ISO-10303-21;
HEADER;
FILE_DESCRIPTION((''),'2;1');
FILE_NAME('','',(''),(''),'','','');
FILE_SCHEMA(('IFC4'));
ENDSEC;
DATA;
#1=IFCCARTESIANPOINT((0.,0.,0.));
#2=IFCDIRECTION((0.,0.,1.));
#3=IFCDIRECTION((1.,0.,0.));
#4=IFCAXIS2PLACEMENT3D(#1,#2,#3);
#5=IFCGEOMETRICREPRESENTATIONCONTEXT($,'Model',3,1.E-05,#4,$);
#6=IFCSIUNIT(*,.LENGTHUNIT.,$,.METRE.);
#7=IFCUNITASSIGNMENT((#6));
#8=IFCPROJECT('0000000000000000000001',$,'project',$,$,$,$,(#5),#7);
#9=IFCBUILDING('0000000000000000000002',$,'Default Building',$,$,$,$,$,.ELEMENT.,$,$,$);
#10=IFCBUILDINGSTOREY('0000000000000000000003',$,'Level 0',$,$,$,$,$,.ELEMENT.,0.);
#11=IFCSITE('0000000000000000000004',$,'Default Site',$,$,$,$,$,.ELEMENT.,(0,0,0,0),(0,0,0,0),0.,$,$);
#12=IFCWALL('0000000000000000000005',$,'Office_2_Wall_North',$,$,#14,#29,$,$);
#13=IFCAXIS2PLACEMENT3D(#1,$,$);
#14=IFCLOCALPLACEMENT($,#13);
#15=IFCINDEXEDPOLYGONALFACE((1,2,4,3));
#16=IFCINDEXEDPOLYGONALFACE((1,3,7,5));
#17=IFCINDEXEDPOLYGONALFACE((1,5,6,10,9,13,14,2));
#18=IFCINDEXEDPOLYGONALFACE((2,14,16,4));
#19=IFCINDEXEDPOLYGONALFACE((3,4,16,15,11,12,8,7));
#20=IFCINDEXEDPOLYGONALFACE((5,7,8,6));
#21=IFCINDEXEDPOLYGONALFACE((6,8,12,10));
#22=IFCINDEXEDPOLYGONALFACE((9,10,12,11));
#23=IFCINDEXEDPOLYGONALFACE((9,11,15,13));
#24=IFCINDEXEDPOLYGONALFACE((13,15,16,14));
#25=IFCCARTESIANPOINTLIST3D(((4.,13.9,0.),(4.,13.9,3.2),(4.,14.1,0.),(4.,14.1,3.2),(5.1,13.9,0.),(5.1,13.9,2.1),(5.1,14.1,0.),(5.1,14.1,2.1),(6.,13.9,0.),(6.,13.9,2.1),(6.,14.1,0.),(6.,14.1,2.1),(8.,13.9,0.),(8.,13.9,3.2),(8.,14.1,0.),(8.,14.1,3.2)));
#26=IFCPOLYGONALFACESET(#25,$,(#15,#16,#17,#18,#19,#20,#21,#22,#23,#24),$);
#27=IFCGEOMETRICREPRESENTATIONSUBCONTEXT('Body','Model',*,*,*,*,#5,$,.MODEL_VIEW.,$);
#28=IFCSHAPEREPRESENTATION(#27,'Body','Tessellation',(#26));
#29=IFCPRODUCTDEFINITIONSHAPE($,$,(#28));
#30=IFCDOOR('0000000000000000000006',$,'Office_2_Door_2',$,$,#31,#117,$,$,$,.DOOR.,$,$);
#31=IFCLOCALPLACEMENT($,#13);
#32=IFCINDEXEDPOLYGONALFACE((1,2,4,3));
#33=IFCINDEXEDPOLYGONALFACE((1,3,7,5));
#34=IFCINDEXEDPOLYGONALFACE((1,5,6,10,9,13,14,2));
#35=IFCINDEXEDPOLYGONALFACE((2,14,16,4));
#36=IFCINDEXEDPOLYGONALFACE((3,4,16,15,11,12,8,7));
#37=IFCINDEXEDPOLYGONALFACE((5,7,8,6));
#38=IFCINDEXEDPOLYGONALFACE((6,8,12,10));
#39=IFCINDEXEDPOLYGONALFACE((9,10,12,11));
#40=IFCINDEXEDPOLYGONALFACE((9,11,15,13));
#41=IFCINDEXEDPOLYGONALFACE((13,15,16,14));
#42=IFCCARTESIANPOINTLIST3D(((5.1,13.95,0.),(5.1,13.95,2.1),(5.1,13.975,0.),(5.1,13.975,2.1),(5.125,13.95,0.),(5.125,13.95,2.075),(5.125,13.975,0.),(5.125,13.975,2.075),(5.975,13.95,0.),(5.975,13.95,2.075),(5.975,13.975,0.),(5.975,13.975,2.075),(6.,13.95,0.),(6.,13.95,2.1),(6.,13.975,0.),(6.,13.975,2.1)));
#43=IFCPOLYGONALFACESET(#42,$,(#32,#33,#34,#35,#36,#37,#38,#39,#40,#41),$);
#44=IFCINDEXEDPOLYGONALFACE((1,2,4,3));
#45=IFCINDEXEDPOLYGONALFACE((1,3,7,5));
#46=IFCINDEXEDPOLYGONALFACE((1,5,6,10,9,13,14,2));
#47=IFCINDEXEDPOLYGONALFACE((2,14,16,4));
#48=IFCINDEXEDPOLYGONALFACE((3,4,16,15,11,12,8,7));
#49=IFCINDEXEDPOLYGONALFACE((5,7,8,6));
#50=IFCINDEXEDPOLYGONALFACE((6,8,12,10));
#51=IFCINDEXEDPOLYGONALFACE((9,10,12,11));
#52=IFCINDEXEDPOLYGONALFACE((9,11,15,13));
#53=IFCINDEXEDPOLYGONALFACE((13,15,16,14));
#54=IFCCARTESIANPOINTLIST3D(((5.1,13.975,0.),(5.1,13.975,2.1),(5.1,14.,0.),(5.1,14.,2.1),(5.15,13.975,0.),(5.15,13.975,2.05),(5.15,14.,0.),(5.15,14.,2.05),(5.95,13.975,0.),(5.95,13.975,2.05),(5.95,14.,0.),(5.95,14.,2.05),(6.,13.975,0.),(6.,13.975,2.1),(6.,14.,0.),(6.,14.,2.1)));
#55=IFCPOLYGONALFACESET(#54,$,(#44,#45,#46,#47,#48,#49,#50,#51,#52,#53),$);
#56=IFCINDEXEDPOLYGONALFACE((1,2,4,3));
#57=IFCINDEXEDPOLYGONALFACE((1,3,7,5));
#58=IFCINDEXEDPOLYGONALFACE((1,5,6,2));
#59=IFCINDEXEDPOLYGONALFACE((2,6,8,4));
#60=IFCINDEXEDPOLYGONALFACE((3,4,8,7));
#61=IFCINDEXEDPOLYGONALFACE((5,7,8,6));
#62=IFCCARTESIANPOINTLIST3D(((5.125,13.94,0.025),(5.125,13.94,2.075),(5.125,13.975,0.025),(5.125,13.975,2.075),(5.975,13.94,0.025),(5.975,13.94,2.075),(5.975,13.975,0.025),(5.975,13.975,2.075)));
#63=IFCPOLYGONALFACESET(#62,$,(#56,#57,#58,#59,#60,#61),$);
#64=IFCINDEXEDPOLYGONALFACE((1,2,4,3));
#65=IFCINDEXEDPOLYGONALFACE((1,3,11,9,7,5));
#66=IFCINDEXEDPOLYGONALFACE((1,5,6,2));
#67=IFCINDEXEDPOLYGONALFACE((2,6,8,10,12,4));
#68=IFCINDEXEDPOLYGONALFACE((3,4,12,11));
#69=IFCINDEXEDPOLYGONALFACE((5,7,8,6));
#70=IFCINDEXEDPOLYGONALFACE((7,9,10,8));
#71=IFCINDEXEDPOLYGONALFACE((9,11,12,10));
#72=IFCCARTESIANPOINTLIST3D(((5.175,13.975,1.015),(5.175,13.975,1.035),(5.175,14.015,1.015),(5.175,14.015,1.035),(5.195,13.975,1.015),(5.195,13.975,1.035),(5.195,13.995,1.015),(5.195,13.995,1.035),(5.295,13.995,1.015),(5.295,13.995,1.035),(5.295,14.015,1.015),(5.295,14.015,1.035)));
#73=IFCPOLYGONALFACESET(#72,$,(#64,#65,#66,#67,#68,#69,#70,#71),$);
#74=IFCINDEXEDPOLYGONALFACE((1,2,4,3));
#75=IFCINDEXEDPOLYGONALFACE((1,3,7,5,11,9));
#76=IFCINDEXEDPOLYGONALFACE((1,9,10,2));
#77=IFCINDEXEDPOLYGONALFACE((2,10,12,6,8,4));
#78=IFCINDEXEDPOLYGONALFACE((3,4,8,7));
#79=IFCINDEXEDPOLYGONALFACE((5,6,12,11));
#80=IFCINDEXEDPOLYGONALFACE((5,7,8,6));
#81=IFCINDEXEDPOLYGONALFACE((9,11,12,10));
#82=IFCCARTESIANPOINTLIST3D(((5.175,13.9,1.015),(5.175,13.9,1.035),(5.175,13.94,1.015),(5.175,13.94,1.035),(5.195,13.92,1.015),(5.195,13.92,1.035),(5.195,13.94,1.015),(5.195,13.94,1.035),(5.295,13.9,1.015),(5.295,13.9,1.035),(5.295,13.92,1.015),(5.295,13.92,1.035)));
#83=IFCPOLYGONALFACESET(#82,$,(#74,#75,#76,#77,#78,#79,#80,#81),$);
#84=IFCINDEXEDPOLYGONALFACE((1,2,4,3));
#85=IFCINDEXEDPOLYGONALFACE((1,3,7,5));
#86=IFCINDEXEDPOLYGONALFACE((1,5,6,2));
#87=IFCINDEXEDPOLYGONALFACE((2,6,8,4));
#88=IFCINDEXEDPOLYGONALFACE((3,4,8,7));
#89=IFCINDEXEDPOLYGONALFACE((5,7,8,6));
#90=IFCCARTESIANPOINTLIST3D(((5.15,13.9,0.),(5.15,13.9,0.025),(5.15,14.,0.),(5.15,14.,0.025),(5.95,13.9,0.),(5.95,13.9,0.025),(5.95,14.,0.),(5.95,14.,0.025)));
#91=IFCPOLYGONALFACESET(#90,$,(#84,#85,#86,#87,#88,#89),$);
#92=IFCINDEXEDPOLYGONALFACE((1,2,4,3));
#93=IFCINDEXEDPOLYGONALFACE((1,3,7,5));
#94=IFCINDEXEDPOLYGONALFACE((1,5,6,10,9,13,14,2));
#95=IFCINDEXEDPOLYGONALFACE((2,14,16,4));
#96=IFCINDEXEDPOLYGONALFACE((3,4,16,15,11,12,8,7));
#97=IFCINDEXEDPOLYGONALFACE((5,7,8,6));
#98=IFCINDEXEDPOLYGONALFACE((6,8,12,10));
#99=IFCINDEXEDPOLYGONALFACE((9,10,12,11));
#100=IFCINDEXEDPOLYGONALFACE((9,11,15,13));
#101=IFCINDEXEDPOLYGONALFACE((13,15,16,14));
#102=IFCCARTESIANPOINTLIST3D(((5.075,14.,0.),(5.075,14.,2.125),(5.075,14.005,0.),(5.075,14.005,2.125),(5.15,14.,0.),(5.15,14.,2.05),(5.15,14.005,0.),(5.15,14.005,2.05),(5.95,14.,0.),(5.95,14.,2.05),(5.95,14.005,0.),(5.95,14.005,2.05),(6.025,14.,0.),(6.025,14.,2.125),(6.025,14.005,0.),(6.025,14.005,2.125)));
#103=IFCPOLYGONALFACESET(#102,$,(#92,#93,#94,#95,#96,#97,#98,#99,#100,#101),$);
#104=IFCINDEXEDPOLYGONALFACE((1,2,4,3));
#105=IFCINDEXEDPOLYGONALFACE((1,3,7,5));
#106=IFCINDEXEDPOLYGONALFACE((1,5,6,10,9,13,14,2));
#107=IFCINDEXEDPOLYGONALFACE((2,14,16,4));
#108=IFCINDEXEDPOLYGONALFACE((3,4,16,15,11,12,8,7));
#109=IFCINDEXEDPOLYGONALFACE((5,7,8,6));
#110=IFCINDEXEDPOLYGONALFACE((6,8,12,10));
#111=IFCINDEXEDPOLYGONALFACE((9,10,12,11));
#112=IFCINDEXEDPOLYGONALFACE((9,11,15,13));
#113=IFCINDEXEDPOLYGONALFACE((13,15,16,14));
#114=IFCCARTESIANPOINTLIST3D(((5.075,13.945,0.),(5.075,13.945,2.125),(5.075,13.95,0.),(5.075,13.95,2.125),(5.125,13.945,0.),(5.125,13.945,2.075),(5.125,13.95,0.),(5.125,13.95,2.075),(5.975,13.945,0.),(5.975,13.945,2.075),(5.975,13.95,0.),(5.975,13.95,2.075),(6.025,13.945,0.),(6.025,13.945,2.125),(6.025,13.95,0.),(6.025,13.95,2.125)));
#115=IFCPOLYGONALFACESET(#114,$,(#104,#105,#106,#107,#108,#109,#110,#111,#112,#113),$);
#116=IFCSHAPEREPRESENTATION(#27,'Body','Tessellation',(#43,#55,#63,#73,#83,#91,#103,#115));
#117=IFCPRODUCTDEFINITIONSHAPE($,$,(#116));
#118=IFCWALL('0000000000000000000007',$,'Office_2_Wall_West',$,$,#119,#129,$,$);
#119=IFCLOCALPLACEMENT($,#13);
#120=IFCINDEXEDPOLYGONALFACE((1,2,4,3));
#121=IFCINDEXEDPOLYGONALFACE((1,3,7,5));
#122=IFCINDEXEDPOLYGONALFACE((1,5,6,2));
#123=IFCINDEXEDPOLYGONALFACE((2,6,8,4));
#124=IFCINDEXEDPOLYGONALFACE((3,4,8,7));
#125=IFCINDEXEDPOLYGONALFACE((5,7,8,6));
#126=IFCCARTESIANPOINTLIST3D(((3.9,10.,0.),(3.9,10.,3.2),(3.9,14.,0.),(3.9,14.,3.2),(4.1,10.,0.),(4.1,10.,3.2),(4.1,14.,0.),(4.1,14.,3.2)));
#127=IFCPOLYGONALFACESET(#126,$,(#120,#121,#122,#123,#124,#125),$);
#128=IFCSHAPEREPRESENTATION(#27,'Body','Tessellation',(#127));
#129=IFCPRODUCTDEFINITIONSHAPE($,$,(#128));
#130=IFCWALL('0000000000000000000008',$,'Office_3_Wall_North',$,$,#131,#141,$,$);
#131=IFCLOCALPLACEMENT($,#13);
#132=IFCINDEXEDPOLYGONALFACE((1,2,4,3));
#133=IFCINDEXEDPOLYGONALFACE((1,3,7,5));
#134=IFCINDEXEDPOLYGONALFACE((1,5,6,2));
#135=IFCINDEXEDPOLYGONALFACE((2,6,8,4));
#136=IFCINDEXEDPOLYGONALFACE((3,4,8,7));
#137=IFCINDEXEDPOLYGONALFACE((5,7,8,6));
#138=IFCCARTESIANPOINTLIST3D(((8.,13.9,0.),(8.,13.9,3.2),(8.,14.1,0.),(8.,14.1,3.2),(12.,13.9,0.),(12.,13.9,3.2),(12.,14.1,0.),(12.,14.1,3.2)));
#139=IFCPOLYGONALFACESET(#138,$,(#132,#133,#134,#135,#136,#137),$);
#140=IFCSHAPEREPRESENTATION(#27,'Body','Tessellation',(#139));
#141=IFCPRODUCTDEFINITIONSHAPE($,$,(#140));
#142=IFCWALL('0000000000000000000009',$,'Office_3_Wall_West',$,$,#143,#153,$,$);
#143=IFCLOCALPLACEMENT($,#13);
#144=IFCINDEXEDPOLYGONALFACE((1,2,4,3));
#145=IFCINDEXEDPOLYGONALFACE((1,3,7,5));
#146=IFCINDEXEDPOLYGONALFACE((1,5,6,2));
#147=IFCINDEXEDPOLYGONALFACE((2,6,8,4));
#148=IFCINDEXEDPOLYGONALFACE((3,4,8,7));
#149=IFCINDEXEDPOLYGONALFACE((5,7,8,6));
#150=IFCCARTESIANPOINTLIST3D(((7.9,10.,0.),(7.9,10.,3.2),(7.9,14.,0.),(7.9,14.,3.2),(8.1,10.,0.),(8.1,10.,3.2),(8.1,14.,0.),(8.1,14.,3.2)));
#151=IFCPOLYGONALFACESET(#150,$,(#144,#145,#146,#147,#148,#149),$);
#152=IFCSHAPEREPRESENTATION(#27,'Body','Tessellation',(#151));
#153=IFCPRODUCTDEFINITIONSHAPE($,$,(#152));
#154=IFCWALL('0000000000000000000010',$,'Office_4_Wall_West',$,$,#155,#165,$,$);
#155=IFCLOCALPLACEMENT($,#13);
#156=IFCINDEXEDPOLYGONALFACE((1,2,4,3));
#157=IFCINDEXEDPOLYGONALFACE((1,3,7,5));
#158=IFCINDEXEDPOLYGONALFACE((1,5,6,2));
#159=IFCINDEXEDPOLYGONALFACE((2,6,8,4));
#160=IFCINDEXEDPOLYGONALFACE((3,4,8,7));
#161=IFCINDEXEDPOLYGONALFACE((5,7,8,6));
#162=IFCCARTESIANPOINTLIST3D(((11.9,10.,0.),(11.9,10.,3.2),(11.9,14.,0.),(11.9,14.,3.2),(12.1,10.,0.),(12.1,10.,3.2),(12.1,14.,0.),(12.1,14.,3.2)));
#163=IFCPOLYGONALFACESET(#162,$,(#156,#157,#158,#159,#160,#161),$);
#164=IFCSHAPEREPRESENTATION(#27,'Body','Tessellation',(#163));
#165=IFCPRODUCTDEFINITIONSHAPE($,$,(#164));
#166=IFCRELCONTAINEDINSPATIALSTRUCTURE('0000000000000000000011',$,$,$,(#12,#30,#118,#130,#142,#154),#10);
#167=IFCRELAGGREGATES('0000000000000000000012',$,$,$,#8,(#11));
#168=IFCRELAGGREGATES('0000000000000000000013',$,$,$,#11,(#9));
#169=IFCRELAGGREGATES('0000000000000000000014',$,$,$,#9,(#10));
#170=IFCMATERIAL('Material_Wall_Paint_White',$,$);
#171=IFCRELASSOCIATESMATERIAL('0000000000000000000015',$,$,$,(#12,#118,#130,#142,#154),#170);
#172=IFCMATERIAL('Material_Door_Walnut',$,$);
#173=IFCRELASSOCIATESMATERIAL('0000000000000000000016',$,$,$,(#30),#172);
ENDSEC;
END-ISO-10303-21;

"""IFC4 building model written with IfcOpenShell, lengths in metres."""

from ifc_helpers import new_model, si_unit, frame, origin_with_axes, place, context, subcontext, project, spatial, line, indexed_curve, outline, extrude, material, element, fill, save


model = new_model("IFC4")

# Units and contexts
model_context = context("Model", 3, precision=1e-05, world=origin_with_axes())
body_context = subcontext(model_context, "Body", "Model", "MODEL_VIEW")
ifc_project = project(units=[si_unit("LENGTHUNIT", "METRE")], contexts=[model_context])

# Site, building, storey
site = spatial("IfcSite", under=ifc_project, Name="Default Site", CompositionType="ELEMENT", RefLatitude=(0, 0, 0, 0), RefLongitude=(0, 0, 0, 0), RefElevation=0.0)
building = spatial("IfcBuilding", under=site, Name="Default Building", CompositionType="ELEMENT")
storey = spatial("IfcBuildingStorey", under=building, Name="Level 0", CompositionType="ELEMENT", Elevation=0.0)

# Shared definitions
ifc_material_1 = material(Name="Material_Wall_Paint_White")

# Wall, opening, door
wall_1_placement = place(None, frame((8.0, 14.0, 0.0), z_axis=(0.0, 0.0, 1.0), x_axis=(-1.0, 0.0, 0.0)))
wall_1 = element("IfcWall", 1, at=wall_1_placement, inside=storey, material=ifc_material_1, Name="Office_2_Wall_North", context=body_context, shape_type="SweptSolid", body=[
    extrude(outline(indexed_curve([(0.0, 0.0), (0.0, 0.2), (4.0, 0.2), (4.0, 0.0), (0.0, 0.0)], self_intersect=False)), frame((0.0, -0.1, 0.0), z_axis=(0.0, 0.0, 1.0), x_axis=(1.0, 0.0, 0.0)), (0.0, 0.0, 1.0), 3.2),
])
opening_1_placement = place(wall_1_placement, frame((2.0, -0.5, 0.0), z_axis=(0.0, 0.0, 1.0), x_axis=(1.0, 0.0, 0.0)))
opening_1 = element("IfcOpeningElement", 2, at=opening_1_placement, inside=storey, cuts=wall_1, PredefinedType="OPENING", context=body_context, shape_type="SweptSolid", body=[
    extrude(outline(indexed_curve([(0.0, 0.0), (0.0, 1.0), (0.9, 1.0), (0.9, 0.0), (0.0, 0.0)], self_intersect=False)), origin_with_axes(), (0.0, 0.0, 1.0), 2.1),
])
ifc_material_2 = material(Name="Material_Door_Walnut")
door_1_placement = place(None, frame((6.0, 14.0, 0.0), z_axis=(0.0, 0.0, 1.0), x_axis=(-1.0, 0.0, 0.0)))
door_1 = element("IfcDoor", 3, at=door_1_placement, inside=storey, material=ifc_material_2, Name="Office_2_Door_2", PredefinedType="DOOR", context=body_context, shape_type="SweptSolid", body=[
    extrude(outline(indexed_curve([(0.0, 0.0), (0.0, 2.1), (0.9, 2.1), (0.9, 0.0), (0.875, 0.0), (0.875, 2.075), (0.025, 2.075), (0.025, 0.0)], segments=[line(1, 2, 3, 4, 5, 6, 7, 8, 1)])), frame((0.0, 0.025, 0.0), z_axis=(0.0, -1.0, 0.0), x_axis=(1.0, 0.0, 0.0)), (0.0, 0.0, -1.0), 0.025),
    extrude(outline(indexed_curve([(0.0, 0.0), (0.0, 2.1), (0.9, 2.1), (0.9, 0.0), (0.85, 0.0), (0.85, 2.05), (0.05, 2.05), (0.05, 0.0)], segments=[line(1, 2, 3, 4, 5, 6, 7, 8, 1)])), frame((0.0, 0.0, 0.0), z_axis=(0.0, -1.0, 0.0), x_axis=(1.0, 0.0, 0.0)), (0.0, 0.0, -1.0), 0.025),
    extrude(outline(indexed_curve([(0.0, 0.0), (0.85, 0.0), (0.85, 0.035), (0.0, 0.035)], segments=[line(1, 2, 3, 4, 1)])), frame((0.025, 0.025, 0.025), z_axis=(0.0, 0.0, 1.0), x_axis=(1.0, 0.0, 0.0)), (0.0, 0.0, 1.0), 2.05),
    extrude(outline(indexed_curve([(0.0, 0.0), (0.0, -0.04), (-0.12, -0.04), (-0.12, -0.02), (-0.02, -0.02), (-0.02, 0.0)], segments=[line(1, 2, 3, 4, 5, 6, 1)])), frame((0.825, 0.025, 1.015), z_axis=(0.0, 0.0, 1.0), x_axis=(1.0, 0.0, 0.0)), (0.0, 0.0, 1.0), 0.02),
    extrude(outline(indexed_curve([(0.0, 0.0), (0.0, 0.04), (-0.12, 0.04), (-0.12, 0.02), (-0.02, 0.02), (-0.02, 0.0)], segments=[line(1, 2, 3, 4, 5, 6, 1)])), frame((0.825, 0.06, 1.015), z_axis=(0.0, 0.0, 1.0), x_axis=(1.0, 0.0, 0.0)), (0.0, 0.0, 1.0), 0.02),
    extrude(outline(indexed_curve([(0.0, 0.0), (0.8, 0.0), (0.8, 0.1), (0.0, 0.1)], segments=[line(1, 2, 3, 4, 1)])), frame((0.05, 0.0, 0.0), z_axis=(0.0, 0.0, 1.0), x_axis=(1.0, 0.0, 0.0)), (0.0, 0.0, 1.0), 0.025),
    extrude(outline(indexed_curve([(0.0, 0.0), (0.0, 2.125), (0.95, 2.125), (0.95, 0.0), (0.875, 0.0), (0.875, 2.05), (0.075, 2.05), (0.075, 0.0)], segments=[line(1, 2, 3, 4, 5, 6, 7, 8, 1)])), frame((-0.025, -0.005, 0.0), z_axis=(0.0, -1.0, 0.0), x_axis=(1.0, 0.0, 0.0)), (0.0, 0.0, -1.0), 0.005),
    extrude(outline(indexed_curve([(0.0, 0.0), (0.0, 2.125), (0.95, 2.125), (0.95, 0.0), (0.9, 0.0), (0.9, 2.075), (0.05, 2.075), (0.05, 0.0)], segments=[line(1, 2, 3, 4, 5, 6, 7, 8, 1)])), frame((-0.025, 0.05, 0.0), z_axis=(0.0, -1.0, 0.0), x_axis=(1.0, 0.0, 0.0)), (0.0, 0.0, -1.0), 0.005),
])
fill(opening_1, door_1)

# Walls
for number, where, z_axis, x_axis, name in (
    (4, (4.0, 14.0, 0.0), (0.0, 0.0, 1.0), (0.0, -1.0, 0.0), "Office_2_Wall_West"),
    (5, (12.0, 14.0, 0.0), (0.0, 0.0, 1.0), (-1.0, 0.0, 0.0), "Office_3_Wall_North"),
    (6, (8.0, 14.0, 0.0), (0.0, 0.0, 1.0), (0.0, -1.0, 0.0), "Office_3_Wall_West"),
    (7, (12.0, 14.0, 0.0), (0.0, 0.0, 1.0), (0.0, -1.0, 0.0), "Office_4_Wall_West"),
):
    element("IfcWall", number, at=place(None, frame(where, z_axis=z_axis, x_axis=x_axis)), inside=storey, material=ifc_material_1, Name=name, context=body_context, shape_type="SweptSolid", body=[
        extrude(outline(indexed_curve([(0.0, 0.0), (0.0, 0.2), (4.0, 0.2), (4.0, 0.0), (0.0, 0.0)], self_intersect=False)), frame((0.0, -0.1, 0.0), z_axis=(0.0, 0.0, 1.0), x_axis=(1.0, 0.0, 0.0)), (0.0, 0.0, 1.0), 3.2),
    ])

save(model, "model.ifc")
